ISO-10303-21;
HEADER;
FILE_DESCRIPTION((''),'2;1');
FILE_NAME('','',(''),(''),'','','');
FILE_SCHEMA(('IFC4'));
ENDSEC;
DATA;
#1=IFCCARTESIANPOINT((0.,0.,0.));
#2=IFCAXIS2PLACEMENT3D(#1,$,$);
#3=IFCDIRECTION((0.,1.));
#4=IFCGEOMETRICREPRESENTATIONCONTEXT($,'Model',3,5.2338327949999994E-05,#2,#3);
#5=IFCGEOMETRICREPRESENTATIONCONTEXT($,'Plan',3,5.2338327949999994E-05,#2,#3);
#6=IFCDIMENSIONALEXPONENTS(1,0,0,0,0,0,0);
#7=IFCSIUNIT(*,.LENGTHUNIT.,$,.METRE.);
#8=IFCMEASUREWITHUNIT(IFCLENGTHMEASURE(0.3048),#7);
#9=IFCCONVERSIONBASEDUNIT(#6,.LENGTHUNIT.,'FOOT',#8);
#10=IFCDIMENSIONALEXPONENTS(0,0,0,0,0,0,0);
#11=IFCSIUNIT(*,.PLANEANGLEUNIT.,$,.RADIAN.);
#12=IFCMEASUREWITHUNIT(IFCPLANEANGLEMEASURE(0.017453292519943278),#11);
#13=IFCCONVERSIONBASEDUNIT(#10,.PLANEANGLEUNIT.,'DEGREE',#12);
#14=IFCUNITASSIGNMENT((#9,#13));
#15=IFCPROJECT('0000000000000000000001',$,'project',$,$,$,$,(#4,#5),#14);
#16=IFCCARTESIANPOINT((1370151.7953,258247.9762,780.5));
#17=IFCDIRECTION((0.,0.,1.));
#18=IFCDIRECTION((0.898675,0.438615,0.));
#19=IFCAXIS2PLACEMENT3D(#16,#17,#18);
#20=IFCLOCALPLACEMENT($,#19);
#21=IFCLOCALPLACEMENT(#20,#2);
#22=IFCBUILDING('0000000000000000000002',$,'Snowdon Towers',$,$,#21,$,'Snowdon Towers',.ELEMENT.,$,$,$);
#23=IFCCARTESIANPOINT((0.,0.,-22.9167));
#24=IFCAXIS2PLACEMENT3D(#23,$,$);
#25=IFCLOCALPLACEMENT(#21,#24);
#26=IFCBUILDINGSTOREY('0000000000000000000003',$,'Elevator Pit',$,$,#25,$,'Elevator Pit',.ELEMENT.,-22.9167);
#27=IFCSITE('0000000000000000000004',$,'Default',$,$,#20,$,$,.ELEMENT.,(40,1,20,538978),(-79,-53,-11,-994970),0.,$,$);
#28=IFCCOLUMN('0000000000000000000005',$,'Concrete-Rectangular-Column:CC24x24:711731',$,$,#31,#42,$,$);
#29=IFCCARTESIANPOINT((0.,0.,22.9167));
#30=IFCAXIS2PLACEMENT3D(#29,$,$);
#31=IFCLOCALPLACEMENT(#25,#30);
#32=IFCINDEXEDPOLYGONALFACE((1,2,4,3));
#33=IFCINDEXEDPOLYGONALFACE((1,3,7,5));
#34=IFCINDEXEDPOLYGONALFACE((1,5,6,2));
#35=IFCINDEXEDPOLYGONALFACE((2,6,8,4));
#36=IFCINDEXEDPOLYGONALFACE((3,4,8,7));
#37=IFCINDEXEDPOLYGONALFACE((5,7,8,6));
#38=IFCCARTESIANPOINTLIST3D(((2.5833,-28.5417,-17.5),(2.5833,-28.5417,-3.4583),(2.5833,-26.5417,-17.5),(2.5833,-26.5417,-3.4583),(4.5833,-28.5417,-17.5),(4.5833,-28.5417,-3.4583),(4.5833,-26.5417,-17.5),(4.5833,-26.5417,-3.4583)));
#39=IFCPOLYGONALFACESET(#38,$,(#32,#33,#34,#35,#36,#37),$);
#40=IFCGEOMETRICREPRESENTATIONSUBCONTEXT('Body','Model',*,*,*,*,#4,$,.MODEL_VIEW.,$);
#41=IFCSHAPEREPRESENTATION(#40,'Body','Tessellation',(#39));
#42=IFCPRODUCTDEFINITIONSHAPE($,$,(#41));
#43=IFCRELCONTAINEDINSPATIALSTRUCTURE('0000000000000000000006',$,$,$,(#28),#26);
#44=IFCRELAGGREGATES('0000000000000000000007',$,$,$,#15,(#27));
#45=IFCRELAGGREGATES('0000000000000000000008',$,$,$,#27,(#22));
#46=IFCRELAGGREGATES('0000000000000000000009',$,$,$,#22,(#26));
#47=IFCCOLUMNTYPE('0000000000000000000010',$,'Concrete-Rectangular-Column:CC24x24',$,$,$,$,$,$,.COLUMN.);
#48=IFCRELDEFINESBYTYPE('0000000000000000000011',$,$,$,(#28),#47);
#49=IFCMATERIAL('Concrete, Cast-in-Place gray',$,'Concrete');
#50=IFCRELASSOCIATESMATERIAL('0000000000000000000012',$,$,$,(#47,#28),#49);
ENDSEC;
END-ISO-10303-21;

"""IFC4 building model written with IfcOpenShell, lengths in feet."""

from ifc_helpers import new_model, entity, si_unit, converted_unit, direction, frame, origin, place, context, subcontext, project, spatial, indexed_curve, outline, extrude, source, transform, mapped, material, type_object, type_shapes, element, save


model = new_model("IFC4")

# Units and contexts
model_context = context("Model", 3, precision=5.2338327949999994e-05, world=origin(), true_north=direction((0.0, 1.0)))
plan_context = context("Plan", 3, precision=5.2338327949999994e-05, world=origin(), true_north=direction((0.0, 1.0)))
body_context = subcontext(model_context, "Body", "Model", "MODEL_VIEW")
ifc_project = project(units=[converted_unit("LENGTHUNIT", "FOOT", entity("IfcLengthMeasure", 0.3048), si_unit("LENGTHUNIT", "METRE"), dimensions=[1, 0, 0, 0, 0, 0, 0]), converted_unit("PLANEANGLEUNIT", "DEGREE", entity("IfcPlaneAngleMeasure", 0.017453292519943278), si_unit("PLANEANGLEUNIT", "RADIAN"), dimensions=[0, 0, 0, 0, 0, 0, 0])], contexts=[model_context, plan_context])

# Site, building, storey
site_placement = place(None, frame((1370151.7953, 258247.9762, 780.5), z_axis=(0.0, 0.0, 1.0), x_axis=(0.898675, 0.438615, 0.0)))
site = spatial("IfcSite", under=ifc_project, at=site_placement, Name="Default", CompositionType="ELEMENT", RefLatitude=(40, 1, 20, 538978), RefLongitude=(-79, -53, -11, -994970), RefElevation=0.0)
building_placement = place(site_placement, origin())
building = spatial("IfcBuilding", under=site, at=building_placement, Name="Snowdon Towers", LongName="Snowdon Towers", CompositionType="ELEMENT")
storey_placement = place(building_placement, frame((0.0, 0.0, -22.9167)))
storey = spatial("IfcBuildingStorey", under=building, at=storey_placement, Name="Elevator Pit", LongName="Elevator Pit", CompositionType="ELEMENT", Elevation=-22.9167)

# Column
ifc_material = material(Name="Concrete, Cast-in-Place gray", Category="Concrete")
column_type_1 = type_object("IfcColumnType", Name="Concrete-Rectangular-Column:CC24x24", PredefinedType="COLUMN", material=ifc_material)
shared_shape_1 = source(origin(), body_context, "Body", "SweptSolid", [
    extrude(outline(indexed_curve([(-1.0, -1.0), (1.0, -1.0), (1.0, 1.0), (-1.0, 1.0), (-1.0, -1.0)], self_intersect=False)), frame((3.5833, -27.5417, -17.5), z_axis=(0.0, 0.0, 1.0), x_axis=(-1.0, 0.0, 0.0)), (0.0, 0.0, 1.0), 14.0417),
])
type_shapes(column_type_1, [shared_shape_1])
column_1_placement = place(storey_placement, frame((0.0, 0.0, 22.9167)))
element("IfcColumn", 1, at=column_1_placement, inside=storey, type_object=column_type_1, material=ifc_material, Name="Concrete-Rectangular-Column:CC24x24:711731", context=body_context, shape_type="MappedRepresentation", body=[
    mapped(shared_shape_1, transform((0.0, 0.0, 0.0), scale=1.0)),
])

save(model, "model.ifc")
